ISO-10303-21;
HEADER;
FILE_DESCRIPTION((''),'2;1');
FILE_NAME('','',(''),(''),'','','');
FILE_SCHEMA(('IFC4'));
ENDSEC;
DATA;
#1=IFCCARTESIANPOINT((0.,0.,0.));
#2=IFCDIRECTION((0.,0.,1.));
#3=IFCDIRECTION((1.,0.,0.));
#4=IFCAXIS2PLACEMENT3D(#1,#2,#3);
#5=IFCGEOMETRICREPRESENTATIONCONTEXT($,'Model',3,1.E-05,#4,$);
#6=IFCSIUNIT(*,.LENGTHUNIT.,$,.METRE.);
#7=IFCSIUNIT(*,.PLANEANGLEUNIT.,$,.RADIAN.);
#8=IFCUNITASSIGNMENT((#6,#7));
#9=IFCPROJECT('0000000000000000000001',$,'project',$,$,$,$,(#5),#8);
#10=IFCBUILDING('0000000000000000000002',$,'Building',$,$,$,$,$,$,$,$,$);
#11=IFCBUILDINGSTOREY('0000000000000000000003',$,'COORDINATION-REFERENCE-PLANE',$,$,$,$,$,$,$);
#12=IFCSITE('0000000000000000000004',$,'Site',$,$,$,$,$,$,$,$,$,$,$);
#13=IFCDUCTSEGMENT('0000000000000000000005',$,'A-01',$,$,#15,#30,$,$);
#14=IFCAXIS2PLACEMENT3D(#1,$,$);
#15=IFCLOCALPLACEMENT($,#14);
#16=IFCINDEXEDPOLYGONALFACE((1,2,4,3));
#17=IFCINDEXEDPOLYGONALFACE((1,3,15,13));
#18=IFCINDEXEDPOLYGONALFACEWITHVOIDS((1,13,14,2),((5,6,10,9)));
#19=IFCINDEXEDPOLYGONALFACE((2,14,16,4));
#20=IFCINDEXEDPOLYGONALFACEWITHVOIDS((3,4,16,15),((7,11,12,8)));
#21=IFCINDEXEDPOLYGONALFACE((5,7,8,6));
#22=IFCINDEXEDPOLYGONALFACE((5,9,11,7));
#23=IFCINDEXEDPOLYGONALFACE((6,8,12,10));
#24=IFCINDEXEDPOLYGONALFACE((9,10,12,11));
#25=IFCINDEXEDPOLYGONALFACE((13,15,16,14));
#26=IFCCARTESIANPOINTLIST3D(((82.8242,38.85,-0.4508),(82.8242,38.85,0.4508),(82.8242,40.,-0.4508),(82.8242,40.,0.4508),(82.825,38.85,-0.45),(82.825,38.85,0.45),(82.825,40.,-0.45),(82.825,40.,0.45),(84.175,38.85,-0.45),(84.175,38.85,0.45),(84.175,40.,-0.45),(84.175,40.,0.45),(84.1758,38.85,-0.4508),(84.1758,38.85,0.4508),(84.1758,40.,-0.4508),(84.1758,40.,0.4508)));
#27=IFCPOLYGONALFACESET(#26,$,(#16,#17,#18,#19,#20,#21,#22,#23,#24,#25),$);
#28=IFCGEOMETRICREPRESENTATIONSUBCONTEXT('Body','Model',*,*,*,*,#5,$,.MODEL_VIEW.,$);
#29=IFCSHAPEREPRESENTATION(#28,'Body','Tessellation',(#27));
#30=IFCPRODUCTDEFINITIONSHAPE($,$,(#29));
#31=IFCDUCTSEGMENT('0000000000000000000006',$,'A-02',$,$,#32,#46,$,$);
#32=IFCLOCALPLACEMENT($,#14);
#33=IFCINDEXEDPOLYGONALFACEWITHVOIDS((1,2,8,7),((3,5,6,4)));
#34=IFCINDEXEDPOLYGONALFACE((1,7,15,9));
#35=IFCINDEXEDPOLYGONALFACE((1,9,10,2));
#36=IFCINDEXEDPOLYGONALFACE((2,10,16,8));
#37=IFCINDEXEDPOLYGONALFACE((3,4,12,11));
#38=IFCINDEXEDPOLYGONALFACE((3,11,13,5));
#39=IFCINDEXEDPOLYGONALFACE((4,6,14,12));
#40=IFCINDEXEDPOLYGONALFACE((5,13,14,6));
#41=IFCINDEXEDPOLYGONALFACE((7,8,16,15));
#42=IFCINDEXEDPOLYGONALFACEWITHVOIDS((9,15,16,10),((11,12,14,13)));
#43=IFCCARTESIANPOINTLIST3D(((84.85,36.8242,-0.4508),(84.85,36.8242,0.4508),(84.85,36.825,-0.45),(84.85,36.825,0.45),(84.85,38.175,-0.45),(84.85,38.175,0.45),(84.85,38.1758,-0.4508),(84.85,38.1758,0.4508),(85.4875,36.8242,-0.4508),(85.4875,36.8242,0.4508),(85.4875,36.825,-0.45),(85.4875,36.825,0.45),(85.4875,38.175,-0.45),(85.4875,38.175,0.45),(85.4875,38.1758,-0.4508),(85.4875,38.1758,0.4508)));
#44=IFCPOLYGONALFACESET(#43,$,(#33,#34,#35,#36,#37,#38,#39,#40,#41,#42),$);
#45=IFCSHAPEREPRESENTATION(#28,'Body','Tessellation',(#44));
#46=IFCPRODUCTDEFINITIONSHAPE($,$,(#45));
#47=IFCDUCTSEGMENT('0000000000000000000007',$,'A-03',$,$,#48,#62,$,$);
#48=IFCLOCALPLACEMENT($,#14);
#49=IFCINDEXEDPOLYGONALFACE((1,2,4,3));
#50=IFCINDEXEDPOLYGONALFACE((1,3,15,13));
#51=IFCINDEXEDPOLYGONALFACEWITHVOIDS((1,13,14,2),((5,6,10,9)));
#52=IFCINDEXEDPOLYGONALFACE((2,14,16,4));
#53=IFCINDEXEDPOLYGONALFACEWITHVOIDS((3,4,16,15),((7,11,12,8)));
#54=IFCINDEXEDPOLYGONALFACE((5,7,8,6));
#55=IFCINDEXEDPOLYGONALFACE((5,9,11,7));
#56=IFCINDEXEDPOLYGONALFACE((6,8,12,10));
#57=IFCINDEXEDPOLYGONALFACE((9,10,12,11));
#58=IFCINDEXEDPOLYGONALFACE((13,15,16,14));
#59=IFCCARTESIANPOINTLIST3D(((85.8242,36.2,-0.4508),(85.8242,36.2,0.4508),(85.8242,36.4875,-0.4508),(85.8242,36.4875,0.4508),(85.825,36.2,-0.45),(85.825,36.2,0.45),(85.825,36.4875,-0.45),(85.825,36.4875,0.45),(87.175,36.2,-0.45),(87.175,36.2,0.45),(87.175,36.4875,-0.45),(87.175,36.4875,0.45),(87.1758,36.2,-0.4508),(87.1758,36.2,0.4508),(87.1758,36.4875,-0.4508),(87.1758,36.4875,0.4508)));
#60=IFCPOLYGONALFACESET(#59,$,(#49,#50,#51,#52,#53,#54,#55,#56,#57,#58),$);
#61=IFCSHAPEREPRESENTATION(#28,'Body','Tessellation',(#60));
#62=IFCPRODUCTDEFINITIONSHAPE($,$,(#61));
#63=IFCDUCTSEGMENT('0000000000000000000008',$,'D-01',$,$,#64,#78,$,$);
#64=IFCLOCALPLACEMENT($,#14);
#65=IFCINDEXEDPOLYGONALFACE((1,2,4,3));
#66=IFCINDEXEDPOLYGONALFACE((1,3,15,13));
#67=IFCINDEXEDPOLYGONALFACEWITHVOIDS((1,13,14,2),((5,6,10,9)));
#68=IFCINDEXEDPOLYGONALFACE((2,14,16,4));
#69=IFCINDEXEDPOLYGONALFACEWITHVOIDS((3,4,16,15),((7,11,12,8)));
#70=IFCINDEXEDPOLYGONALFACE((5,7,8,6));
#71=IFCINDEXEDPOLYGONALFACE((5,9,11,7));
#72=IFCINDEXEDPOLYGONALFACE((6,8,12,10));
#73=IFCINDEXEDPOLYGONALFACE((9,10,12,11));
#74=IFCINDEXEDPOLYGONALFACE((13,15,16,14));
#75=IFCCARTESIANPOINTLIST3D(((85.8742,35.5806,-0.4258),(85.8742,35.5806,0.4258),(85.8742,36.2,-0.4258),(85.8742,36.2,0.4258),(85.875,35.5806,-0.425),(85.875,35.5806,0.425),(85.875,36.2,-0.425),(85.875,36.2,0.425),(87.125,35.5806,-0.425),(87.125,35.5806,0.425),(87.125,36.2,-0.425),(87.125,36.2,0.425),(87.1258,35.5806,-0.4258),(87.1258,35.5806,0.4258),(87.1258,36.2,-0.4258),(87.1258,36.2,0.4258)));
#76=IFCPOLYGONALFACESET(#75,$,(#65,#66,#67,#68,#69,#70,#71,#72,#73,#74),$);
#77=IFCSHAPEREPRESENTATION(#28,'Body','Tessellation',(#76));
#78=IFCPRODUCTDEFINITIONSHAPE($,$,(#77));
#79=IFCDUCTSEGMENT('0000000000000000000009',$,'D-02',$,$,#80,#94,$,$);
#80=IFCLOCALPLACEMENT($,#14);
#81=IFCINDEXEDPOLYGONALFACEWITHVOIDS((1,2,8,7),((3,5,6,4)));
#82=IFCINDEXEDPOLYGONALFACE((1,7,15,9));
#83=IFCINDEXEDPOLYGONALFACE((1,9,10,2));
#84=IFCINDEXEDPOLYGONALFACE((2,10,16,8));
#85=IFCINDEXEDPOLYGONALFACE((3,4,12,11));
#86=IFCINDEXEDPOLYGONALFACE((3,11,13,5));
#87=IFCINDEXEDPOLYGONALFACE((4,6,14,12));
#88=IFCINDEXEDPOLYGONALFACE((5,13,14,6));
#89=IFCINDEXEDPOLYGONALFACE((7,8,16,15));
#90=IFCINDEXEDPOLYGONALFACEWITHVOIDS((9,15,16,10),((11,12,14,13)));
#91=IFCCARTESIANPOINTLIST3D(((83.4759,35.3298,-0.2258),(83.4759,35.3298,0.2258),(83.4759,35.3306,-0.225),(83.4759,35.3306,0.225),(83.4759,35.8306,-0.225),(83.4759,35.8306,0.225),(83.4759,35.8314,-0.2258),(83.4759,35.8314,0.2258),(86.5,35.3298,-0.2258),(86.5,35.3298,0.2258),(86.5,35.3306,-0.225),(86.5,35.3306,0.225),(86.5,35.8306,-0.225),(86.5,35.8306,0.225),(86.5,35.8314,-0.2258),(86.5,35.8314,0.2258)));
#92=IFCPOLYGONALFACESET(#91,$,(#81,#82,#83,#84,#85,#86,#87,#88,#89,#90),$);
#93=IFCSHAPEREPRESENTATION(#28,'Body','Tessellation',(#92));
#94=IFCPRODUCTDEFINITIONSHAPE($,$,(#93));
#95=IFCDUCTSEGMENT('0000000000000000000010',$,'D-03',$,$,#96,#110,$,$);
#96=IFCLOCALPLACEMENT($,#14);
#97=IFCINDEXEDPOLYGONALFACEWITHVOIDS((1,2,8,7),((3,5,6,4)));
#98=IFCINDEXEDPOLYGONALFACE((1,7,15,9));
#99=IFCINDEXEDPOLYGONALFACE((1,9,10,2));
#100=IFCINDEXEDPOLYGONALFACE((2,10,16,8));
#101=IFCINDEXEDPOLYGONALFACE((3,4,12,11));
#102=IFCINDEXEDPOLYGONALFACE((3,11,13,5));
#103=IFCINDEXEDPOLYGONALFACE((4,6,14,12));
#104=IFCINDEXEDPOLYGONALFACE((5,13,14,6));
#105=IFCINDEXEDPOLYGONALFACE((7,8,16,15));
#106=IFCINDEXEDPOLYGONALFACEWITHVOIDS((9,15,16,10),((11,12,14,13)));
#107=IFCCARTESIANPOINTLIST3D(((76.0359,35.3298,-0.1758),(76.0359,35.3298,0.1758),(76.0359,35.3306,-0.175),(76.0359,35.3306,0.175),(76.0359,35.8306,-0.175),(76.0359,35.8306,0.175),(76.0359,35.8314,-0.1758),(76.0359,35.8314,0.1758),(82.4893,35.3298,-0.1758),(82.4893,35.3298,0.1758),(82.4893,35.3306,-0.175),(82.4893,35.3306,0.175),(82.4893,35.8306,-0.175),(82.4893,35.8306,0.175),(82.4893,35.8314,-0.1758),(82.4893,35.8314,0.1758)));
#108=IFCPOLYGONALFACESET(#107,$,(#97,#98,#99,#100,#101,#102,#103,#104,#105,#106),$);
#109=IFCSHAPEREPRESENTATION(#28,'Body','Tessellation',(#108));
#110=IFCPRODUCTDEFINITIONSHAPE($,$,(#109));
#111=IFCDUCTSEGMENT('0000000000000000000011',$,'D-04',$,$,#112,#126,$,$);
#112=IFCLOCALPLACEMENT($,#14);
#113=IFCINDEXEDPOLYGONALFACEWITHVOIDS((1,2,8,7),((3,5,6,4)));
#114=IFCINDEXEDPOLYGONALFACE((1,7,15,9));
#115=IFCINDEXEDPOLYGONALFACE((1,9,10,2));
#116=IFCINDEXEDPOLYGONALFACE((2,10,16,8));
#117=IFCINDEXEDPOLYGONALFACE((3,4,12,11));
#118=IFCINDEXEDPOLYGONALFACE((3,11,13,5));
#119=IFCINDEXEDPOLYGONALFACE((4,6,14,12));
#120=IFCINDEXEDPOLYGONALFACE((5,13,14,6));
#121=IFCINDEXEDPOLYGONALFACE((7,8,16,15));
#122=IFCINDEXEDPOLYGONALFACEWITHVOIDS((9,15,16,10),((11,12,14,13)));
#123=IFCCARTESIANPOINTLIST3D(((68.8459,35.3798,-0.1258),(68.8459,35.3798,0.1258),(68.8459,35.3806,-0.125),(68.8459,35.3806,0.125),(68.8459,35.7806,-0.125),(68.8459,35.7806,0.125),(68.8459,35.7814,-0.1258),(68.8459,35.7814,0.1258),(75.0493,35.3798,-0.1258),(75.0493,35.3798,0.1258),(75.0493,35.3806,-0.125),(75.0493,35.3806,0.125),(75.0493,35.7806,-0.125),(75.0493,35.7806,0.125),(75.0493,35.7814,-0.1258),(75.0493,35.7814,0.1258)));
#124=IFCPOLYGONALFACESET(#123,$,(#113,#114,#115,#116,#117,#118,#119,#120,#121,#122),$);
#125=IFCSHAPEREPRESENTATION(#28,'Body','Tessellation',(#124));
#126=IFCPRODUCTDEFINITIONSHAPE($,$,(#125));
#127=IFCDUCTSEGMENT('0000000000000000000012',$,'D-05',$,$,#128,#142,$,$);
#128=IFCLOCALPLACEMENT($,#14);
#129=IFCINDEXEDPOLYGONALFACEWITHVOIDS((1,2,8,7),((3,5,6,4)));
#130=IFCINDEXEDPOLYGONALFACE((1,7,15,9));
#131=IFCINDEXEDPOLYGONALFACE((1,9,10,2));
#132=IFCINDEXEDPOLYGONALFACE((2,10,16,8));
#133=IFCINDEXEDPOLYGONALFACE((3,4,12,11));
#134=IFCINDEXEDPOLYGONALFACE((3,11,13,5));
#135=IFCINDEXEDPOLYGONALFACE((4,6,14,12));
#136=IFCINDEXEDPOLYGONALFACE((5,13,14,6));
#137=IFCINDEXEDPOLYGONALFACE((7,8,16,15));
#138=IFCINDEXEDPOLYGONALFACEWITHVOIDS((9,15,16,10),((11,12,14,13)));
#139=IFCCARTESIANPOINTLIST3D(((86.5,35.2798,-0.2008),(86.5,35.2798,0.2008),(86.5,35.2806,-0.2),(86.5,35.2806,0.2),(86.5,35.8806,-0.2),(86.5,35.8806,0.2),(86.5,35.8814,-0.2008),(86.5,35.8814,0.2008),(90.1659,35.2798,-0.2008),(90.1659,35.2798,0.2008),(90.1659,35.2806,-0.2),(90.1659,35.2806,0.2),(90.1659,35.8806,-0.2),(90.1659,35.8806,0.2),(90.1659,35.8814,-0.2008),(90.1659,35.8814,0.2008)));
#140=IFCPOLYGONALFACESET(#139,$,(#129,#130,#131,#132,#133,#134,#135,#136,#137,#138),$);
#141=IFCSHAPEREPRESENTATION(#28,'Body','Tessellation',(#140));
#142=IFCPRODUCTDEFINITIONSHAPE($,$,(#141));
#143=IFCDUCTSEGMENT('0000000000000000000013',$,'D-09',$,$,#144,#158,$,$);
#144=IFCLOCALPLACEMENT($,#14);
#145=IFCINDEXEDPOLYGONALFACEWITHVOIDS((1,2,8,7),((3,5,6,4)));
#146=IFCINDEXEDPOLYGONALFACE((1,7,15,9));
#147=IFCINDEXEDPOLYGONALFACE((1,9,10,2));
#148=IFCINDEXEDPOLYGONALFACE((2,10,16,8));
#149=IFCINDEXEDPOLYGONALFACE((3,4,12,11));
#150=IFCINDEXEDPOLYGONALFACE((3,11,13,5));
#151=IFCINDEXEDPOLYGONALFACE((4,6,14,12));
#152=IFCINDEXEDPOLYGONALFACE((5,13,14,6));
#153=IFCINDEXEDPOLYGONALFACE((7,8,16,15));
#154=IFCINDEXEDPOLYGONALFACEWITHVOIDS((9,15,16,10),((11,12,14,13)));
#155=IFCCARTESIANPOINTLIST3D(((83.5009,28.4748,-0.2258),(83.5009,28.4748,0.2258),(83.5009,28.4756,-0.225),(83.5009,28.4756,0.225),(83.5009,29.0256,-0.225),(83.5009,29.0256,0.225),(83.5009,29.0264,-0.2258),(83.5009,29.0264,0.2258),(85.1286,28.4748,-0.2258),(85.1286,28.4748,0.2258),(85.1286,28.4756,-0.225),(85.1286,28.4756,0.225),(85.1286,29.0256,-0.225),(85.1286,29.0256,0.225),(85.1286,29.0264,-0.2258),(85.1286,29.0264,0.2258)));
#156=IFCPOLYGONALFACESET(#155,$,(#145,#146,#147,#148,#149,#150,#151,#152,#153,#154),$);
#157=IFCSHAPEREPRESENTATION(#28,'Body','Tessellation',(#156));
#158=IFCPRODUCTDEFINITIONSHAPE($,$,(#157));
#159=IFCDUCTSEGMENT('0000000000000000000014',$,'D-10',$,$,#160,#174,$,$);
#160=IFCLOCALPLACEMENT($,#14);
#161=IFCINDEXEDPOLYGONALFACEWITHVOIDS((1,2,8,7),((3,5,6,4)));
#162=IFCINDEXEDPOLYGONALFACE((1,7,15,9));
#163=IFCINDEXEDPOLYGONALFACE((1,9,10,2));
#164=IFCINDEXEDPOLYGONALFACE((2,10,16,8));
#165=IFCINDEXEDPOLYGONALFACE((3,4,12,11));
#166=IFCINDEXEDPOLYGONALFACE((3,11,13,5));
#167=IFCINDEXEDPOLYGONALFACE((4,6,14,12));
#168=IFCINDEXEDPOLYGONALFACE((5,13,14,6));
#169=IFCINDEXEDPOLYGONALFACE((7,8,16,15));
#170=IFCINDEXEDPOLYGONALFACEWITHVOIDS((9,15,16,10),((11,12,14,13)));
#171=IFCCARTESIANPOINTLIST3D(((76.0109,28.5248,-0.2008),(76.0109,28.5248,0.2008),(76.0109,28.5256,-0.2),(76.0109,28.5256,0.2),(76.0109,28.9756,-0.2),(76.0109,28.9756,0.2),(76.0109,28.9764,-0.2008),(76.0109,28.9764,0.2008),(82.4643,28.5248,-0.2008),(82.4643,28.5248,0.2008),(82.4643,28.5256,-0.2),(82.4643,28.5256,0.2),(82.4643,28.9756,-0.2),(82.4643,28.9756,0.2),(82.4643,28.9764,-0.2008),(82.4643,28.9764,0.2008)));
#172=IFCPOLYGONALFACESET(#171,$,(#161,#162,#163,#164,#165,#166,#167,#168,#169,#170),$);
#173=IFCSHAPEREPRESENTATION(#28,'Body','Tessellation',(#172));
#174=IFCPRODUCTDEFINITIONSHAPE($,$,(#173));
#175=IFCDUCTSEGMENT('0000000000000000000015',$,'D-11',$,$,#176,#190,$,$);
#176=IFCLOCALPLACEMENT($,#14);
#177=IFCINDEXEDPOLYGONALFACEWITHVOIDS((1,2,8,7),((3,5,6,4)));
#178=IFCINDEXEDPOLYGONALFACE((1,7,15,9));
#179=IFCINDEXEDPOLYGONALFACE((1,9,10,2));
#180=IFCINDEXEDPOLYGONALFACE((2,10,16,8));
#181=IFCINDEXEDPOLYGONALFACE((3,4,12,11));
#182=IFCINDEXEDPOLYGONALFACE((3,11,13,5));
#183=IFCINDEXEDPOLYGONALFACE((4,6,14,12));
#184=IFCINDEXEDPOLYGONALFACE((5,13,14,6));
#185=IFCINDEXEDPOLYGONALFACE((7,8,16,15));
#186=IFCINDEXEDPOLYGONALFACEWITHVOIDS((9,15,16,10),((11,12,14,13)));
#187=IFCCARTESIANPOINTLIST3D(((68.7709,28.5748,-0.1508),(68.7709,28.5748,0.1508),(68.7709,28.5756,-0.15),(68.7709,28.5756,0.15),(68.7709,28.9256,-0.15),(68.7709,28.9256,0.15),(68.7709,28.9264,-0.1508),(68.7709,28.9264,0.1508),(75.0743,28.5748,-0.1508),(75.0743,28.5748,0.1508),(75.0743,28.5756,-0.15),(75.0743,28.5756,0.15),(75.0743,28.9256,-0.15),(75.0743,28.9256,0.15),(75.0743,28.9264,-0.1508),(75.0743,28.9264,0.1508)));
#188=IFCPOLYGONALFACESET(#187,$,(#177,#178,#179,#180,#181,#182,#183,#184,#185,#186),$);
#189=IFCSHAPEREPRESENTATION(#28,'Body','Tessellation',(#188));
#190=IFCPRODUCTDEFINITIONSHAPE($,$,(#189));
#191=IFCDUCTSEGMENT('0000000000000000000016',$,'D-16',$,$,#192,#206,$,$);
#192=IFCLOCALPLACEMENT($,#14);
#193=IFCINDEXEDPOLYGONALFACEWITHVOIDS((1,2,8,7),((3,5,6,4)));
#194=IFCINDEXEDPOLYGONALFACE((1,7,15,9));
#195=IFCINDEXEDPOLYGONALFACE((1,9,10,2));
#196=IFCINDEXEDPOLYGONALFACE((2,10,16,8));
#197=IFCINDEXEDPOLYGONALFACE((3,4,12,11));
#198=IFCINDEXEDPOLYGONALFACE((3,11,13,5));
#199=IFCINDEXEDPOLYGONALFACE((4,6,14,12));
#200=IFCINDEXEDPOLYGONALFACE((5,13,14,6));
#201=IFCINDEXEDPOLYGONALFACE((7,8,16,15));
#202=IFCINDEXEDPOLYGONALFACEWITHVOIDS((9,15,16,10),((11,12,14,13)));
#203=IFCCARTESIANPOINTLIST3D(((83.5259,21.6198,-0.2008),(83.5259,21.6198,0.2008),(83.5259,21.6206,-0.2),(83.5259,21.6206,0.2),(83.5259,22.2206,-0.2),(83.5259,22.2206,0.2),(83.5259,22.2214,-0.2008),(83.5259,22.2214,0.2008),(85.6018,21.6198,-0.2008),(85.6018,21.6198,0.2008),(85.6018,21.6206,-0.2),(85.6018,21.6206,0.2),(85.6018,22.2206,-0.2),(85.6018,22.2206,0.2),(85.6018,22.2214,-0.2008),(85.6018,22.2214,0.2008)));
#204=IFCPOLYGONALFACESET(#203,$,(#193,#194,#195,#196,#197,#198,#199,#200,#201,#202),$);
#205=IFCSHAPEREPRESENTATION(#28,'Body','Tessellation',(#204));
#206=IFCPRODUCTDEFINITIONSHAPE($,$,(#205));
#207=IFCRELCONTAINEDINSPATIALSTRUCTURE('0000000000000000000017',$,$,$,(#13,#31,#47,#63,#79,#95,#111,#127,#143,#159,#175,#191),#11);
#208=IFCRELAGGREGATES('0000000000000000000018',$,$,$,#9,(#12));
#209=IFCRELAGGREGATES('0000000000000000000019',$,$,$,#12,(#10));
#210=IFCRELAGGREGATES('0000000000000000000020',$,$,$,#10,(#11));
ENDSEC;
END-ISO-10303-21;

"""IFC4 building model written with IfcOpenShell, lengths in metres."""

from ifc_helpers import new_model, si_unit, frame, origin, origin_with_axes, place, context, subcontext, project, spatial, hollow_rectangle, extrude, element, save


model = new_model("IFC4")

# Units and contexts
model_context = context("Model", 3, precision=1e-05, world=origin_with_axes())
body_context = subcontext(model_context, "Body", "Model", "MODEL_VIEW")
ifc_project = project(units=[si_unit("LENGTHUNIT", "METRE"), si_unit("PLANEANGLEUNIT", "RADIAN")], contexts=[model_context])

# Site, building, storey
site = spatial("IfcSite", under=ifc_project, Name="Site")
building = spatial("IfcBuilding", under=site, Name="Building")
storey = spatial("IfcBuildingStorey", under=building, Name="COORDINATION-REFERENCE-PLANE")

# Duct segments
duct_segment_1_placement = place(None, frame((83.5, 38.85, 0.0), z_axis=(0.0, 1.0, 0.0), x_axis=(1.0, 0.0, 0.0)))
element("IfcDuctSegment", 1, at=duct_segment_1_placement, inside=storey, Name="A-01", context=body_context, shape_type="SweptSolid", body=[
    extrude(hollow_rectangle(XDim=1.3516, YDim=0.9016, WallThickness=0.0008), origin(), (0.0, 0.0, 1.0), 1.15),
])
duct_segment_2_placement = place(None, frame((84.85, 37.5, 0.0), z_axis=(1.0, 0.0, 0.0), x_axis=(0.0, 1.0, 0.0)))
element("IfcDuctSegment", 2, at=duct_segment_2_placement, inside=storey, Name="A-02", context=body_context, shape_type="SweptSolid", body=[
    extrude(hollow_rectangle(XDim=1.3516, YDim=0.9016, WallThickness=0.0008), origin(), (0.0, 0.0, 1.0), 0.6375),
])
duct_segment_3_placement = place(None, frame((86.5, 36.2, 0.0), z_axis=(0.0, 1.0, 0.0), x_axis=(1.0, 0.0, 0.0)))
element("IfcDuctSegment", 3, at=duct_segment_3_placement, inside=storey, Name="A-03", context=body_context, shape_type="SweptSolid", body=[
    extrude(hollow_rectangle(XDim=1.3516, YDim=0.9016, WallThickness=0.0008), origin(), (0.0, 0.0, 1.0), 0.2875),
])
duct_segment_4_placement = place(None, frame((86.5, 35.5806, 0.0), z_axis=(0.0, 1.0, 0.0), x_axis=(1.0, 0.0, 0.0)))
element("IfcDuctSegment", 4, at=duct_segment_4_placement, inside=storey, Name="D-01", context=body_context, shape_type="SweptSolid", body=[
    extrude(hollow_rectangle(XDim=1.2516, YDim=0.8516, WallThickness=0.0008), origin(), (0.0, 0.0, 1.0), 0.6194),
])
duct_segment_5_placement = place(None, frame((83.4759, 35.5806, 0.0), z_axis=(1.0, 0.0, 0.0), x_axis=(0.0, 1.0, 0.0)))
element("IfcDuctSegment", 5, at=duct_segment_5_placement, inside=storey, Name="D-02", context=body_context, shape_type="SweptSolid", body=[
    extrude(hollow_rectangle(XDim=0.5016, YDim=0.4516, WallThickness=0.0008), origin(), (0.0, 0.0, 1.0), 3.0241),
])
duct_segment_6_placement = place(None, frame((76.0359, 35.5806, 0.0), z_axis=(1.0, 0.0, 0.0), x_axis=(0.0, 1.0, 0.0)))
element("IfcDuctSegment", 6, at=duct_segment_6_placement, inside=storey, Name="D-03", context=body_context, shape_type="SweptSolid", body=[
    extrude(hollow_rectangle(XDim=0.5016, YDim=0.3516, WallThickness=0.0008), origin(), (0.0, 0.0, 1.0), 6.4534),
])
duct_segment_7_placement = place(None, frame((68.8459, 35.5806, 0.0), z_axis=(1.0, 0.0, 0.0), x_axis=(0.0, 1.0, 0.0)))
element("IfcDuctSegment", 7, at=duct_segment_7_placement, inside=storey, Name="D-04", context=body_context, shape_type="SweptSolid", body=[
    extrude(hollow_rectangle(XDim=0.4016, YDim=0.2516, WallThickness=0.0008), origin(), (0.0, 0.0, 1.0), 6.2034),
])
duct_segment_8_placement = place(None, frame((86.5, 35.5806, 0.0), z_axis=(1.0, 0.0, 0.0), x_axis=(0.0, 1.0, 0.0)))
element("IfcDuctSegment", 8, at=duct_segment_8_placement, inside=storey, Name="D-05", context=body_context, shape_type="SweptSolid", body=[
    extrude(hollow_rectangle(XDim=0.6016, YDim=0.4016, WallThickness=0.0008), origin(), (0.0, 0.0, 1.0), 3.6659),
])
duct_segment_9_placement = place(None, frame((83.5009, 28.7506, 0.0), z_axis=(1.0, 0.0, 0.0), x_axis=(0.0, 1.0, 0.0)))
element("IfcDuctSegment", 9, at=duct_segment_9_placement, inside=storey, Name="D-09", context=body_context, shape_type="SweptSolid", body=[
    extrude(hollow_rectangle(XDim=0.5516, YDim=0.4516, WallThickness=0.0008), origin(), (0.0, 0.0, 1.0), 1.6277),
])
duct_segment_10_placement = place(None, frame((76.0109, 28.7506, 0.0), z_axis=(1.0, 0.0, 0.0), x_axis=(0.0, 1.0, 0.0)))
element("IfcDuctSegment", 10, at=duct_segment_10_placement, inside=storey, Name="D-10", context=body_context, shape_type="SweptSolid", body=[
    extrude(hollow_rectangle(XDim=0.4516, YDim=0.4016, WallThickness=0.0008), origin(), (0.0, 0.0, 1.0), 6.4534),
])
duct_segment_11_placement = place(None, frame((68.7709, 28.7506, 0.0), z_axis=(1.0, 0.0, 0.0), x_axis=(0.0, 1.0, 0.0)))
element("IfcDuctSegment", 11, at=duct_segment_11_placement, inside=storey, Name="D-11", context=body_context, shape_type="SweptSolid", body=[
    extrude(hollow_rectangle(XDim=0.3516, YDim=0.3016, WallThickness=0.0008), origin(), (0.0, 0.0, 1.0), 6.3034),
])
duct_segment_12_placement = place(None, frame((83.5259, 21.9206, 0.0), z_axis=(1.0, 0.0, 0.0), x_axis=(0.0, 1.0, 0.0)))
element("IfcDuctSegment", 12, at=duct_segment_12_placement, inside=storey, Name="D-16", context=body_context, shape_type="SweptSolid", body=[
    extrude(hollow_rectangle(XDim=0.6016, YDim=0.4016, WallThickness=0.0008), origin(), (0.0, 0.0, 1.0), 2.0759),
])

save(model, "model.ifc")
